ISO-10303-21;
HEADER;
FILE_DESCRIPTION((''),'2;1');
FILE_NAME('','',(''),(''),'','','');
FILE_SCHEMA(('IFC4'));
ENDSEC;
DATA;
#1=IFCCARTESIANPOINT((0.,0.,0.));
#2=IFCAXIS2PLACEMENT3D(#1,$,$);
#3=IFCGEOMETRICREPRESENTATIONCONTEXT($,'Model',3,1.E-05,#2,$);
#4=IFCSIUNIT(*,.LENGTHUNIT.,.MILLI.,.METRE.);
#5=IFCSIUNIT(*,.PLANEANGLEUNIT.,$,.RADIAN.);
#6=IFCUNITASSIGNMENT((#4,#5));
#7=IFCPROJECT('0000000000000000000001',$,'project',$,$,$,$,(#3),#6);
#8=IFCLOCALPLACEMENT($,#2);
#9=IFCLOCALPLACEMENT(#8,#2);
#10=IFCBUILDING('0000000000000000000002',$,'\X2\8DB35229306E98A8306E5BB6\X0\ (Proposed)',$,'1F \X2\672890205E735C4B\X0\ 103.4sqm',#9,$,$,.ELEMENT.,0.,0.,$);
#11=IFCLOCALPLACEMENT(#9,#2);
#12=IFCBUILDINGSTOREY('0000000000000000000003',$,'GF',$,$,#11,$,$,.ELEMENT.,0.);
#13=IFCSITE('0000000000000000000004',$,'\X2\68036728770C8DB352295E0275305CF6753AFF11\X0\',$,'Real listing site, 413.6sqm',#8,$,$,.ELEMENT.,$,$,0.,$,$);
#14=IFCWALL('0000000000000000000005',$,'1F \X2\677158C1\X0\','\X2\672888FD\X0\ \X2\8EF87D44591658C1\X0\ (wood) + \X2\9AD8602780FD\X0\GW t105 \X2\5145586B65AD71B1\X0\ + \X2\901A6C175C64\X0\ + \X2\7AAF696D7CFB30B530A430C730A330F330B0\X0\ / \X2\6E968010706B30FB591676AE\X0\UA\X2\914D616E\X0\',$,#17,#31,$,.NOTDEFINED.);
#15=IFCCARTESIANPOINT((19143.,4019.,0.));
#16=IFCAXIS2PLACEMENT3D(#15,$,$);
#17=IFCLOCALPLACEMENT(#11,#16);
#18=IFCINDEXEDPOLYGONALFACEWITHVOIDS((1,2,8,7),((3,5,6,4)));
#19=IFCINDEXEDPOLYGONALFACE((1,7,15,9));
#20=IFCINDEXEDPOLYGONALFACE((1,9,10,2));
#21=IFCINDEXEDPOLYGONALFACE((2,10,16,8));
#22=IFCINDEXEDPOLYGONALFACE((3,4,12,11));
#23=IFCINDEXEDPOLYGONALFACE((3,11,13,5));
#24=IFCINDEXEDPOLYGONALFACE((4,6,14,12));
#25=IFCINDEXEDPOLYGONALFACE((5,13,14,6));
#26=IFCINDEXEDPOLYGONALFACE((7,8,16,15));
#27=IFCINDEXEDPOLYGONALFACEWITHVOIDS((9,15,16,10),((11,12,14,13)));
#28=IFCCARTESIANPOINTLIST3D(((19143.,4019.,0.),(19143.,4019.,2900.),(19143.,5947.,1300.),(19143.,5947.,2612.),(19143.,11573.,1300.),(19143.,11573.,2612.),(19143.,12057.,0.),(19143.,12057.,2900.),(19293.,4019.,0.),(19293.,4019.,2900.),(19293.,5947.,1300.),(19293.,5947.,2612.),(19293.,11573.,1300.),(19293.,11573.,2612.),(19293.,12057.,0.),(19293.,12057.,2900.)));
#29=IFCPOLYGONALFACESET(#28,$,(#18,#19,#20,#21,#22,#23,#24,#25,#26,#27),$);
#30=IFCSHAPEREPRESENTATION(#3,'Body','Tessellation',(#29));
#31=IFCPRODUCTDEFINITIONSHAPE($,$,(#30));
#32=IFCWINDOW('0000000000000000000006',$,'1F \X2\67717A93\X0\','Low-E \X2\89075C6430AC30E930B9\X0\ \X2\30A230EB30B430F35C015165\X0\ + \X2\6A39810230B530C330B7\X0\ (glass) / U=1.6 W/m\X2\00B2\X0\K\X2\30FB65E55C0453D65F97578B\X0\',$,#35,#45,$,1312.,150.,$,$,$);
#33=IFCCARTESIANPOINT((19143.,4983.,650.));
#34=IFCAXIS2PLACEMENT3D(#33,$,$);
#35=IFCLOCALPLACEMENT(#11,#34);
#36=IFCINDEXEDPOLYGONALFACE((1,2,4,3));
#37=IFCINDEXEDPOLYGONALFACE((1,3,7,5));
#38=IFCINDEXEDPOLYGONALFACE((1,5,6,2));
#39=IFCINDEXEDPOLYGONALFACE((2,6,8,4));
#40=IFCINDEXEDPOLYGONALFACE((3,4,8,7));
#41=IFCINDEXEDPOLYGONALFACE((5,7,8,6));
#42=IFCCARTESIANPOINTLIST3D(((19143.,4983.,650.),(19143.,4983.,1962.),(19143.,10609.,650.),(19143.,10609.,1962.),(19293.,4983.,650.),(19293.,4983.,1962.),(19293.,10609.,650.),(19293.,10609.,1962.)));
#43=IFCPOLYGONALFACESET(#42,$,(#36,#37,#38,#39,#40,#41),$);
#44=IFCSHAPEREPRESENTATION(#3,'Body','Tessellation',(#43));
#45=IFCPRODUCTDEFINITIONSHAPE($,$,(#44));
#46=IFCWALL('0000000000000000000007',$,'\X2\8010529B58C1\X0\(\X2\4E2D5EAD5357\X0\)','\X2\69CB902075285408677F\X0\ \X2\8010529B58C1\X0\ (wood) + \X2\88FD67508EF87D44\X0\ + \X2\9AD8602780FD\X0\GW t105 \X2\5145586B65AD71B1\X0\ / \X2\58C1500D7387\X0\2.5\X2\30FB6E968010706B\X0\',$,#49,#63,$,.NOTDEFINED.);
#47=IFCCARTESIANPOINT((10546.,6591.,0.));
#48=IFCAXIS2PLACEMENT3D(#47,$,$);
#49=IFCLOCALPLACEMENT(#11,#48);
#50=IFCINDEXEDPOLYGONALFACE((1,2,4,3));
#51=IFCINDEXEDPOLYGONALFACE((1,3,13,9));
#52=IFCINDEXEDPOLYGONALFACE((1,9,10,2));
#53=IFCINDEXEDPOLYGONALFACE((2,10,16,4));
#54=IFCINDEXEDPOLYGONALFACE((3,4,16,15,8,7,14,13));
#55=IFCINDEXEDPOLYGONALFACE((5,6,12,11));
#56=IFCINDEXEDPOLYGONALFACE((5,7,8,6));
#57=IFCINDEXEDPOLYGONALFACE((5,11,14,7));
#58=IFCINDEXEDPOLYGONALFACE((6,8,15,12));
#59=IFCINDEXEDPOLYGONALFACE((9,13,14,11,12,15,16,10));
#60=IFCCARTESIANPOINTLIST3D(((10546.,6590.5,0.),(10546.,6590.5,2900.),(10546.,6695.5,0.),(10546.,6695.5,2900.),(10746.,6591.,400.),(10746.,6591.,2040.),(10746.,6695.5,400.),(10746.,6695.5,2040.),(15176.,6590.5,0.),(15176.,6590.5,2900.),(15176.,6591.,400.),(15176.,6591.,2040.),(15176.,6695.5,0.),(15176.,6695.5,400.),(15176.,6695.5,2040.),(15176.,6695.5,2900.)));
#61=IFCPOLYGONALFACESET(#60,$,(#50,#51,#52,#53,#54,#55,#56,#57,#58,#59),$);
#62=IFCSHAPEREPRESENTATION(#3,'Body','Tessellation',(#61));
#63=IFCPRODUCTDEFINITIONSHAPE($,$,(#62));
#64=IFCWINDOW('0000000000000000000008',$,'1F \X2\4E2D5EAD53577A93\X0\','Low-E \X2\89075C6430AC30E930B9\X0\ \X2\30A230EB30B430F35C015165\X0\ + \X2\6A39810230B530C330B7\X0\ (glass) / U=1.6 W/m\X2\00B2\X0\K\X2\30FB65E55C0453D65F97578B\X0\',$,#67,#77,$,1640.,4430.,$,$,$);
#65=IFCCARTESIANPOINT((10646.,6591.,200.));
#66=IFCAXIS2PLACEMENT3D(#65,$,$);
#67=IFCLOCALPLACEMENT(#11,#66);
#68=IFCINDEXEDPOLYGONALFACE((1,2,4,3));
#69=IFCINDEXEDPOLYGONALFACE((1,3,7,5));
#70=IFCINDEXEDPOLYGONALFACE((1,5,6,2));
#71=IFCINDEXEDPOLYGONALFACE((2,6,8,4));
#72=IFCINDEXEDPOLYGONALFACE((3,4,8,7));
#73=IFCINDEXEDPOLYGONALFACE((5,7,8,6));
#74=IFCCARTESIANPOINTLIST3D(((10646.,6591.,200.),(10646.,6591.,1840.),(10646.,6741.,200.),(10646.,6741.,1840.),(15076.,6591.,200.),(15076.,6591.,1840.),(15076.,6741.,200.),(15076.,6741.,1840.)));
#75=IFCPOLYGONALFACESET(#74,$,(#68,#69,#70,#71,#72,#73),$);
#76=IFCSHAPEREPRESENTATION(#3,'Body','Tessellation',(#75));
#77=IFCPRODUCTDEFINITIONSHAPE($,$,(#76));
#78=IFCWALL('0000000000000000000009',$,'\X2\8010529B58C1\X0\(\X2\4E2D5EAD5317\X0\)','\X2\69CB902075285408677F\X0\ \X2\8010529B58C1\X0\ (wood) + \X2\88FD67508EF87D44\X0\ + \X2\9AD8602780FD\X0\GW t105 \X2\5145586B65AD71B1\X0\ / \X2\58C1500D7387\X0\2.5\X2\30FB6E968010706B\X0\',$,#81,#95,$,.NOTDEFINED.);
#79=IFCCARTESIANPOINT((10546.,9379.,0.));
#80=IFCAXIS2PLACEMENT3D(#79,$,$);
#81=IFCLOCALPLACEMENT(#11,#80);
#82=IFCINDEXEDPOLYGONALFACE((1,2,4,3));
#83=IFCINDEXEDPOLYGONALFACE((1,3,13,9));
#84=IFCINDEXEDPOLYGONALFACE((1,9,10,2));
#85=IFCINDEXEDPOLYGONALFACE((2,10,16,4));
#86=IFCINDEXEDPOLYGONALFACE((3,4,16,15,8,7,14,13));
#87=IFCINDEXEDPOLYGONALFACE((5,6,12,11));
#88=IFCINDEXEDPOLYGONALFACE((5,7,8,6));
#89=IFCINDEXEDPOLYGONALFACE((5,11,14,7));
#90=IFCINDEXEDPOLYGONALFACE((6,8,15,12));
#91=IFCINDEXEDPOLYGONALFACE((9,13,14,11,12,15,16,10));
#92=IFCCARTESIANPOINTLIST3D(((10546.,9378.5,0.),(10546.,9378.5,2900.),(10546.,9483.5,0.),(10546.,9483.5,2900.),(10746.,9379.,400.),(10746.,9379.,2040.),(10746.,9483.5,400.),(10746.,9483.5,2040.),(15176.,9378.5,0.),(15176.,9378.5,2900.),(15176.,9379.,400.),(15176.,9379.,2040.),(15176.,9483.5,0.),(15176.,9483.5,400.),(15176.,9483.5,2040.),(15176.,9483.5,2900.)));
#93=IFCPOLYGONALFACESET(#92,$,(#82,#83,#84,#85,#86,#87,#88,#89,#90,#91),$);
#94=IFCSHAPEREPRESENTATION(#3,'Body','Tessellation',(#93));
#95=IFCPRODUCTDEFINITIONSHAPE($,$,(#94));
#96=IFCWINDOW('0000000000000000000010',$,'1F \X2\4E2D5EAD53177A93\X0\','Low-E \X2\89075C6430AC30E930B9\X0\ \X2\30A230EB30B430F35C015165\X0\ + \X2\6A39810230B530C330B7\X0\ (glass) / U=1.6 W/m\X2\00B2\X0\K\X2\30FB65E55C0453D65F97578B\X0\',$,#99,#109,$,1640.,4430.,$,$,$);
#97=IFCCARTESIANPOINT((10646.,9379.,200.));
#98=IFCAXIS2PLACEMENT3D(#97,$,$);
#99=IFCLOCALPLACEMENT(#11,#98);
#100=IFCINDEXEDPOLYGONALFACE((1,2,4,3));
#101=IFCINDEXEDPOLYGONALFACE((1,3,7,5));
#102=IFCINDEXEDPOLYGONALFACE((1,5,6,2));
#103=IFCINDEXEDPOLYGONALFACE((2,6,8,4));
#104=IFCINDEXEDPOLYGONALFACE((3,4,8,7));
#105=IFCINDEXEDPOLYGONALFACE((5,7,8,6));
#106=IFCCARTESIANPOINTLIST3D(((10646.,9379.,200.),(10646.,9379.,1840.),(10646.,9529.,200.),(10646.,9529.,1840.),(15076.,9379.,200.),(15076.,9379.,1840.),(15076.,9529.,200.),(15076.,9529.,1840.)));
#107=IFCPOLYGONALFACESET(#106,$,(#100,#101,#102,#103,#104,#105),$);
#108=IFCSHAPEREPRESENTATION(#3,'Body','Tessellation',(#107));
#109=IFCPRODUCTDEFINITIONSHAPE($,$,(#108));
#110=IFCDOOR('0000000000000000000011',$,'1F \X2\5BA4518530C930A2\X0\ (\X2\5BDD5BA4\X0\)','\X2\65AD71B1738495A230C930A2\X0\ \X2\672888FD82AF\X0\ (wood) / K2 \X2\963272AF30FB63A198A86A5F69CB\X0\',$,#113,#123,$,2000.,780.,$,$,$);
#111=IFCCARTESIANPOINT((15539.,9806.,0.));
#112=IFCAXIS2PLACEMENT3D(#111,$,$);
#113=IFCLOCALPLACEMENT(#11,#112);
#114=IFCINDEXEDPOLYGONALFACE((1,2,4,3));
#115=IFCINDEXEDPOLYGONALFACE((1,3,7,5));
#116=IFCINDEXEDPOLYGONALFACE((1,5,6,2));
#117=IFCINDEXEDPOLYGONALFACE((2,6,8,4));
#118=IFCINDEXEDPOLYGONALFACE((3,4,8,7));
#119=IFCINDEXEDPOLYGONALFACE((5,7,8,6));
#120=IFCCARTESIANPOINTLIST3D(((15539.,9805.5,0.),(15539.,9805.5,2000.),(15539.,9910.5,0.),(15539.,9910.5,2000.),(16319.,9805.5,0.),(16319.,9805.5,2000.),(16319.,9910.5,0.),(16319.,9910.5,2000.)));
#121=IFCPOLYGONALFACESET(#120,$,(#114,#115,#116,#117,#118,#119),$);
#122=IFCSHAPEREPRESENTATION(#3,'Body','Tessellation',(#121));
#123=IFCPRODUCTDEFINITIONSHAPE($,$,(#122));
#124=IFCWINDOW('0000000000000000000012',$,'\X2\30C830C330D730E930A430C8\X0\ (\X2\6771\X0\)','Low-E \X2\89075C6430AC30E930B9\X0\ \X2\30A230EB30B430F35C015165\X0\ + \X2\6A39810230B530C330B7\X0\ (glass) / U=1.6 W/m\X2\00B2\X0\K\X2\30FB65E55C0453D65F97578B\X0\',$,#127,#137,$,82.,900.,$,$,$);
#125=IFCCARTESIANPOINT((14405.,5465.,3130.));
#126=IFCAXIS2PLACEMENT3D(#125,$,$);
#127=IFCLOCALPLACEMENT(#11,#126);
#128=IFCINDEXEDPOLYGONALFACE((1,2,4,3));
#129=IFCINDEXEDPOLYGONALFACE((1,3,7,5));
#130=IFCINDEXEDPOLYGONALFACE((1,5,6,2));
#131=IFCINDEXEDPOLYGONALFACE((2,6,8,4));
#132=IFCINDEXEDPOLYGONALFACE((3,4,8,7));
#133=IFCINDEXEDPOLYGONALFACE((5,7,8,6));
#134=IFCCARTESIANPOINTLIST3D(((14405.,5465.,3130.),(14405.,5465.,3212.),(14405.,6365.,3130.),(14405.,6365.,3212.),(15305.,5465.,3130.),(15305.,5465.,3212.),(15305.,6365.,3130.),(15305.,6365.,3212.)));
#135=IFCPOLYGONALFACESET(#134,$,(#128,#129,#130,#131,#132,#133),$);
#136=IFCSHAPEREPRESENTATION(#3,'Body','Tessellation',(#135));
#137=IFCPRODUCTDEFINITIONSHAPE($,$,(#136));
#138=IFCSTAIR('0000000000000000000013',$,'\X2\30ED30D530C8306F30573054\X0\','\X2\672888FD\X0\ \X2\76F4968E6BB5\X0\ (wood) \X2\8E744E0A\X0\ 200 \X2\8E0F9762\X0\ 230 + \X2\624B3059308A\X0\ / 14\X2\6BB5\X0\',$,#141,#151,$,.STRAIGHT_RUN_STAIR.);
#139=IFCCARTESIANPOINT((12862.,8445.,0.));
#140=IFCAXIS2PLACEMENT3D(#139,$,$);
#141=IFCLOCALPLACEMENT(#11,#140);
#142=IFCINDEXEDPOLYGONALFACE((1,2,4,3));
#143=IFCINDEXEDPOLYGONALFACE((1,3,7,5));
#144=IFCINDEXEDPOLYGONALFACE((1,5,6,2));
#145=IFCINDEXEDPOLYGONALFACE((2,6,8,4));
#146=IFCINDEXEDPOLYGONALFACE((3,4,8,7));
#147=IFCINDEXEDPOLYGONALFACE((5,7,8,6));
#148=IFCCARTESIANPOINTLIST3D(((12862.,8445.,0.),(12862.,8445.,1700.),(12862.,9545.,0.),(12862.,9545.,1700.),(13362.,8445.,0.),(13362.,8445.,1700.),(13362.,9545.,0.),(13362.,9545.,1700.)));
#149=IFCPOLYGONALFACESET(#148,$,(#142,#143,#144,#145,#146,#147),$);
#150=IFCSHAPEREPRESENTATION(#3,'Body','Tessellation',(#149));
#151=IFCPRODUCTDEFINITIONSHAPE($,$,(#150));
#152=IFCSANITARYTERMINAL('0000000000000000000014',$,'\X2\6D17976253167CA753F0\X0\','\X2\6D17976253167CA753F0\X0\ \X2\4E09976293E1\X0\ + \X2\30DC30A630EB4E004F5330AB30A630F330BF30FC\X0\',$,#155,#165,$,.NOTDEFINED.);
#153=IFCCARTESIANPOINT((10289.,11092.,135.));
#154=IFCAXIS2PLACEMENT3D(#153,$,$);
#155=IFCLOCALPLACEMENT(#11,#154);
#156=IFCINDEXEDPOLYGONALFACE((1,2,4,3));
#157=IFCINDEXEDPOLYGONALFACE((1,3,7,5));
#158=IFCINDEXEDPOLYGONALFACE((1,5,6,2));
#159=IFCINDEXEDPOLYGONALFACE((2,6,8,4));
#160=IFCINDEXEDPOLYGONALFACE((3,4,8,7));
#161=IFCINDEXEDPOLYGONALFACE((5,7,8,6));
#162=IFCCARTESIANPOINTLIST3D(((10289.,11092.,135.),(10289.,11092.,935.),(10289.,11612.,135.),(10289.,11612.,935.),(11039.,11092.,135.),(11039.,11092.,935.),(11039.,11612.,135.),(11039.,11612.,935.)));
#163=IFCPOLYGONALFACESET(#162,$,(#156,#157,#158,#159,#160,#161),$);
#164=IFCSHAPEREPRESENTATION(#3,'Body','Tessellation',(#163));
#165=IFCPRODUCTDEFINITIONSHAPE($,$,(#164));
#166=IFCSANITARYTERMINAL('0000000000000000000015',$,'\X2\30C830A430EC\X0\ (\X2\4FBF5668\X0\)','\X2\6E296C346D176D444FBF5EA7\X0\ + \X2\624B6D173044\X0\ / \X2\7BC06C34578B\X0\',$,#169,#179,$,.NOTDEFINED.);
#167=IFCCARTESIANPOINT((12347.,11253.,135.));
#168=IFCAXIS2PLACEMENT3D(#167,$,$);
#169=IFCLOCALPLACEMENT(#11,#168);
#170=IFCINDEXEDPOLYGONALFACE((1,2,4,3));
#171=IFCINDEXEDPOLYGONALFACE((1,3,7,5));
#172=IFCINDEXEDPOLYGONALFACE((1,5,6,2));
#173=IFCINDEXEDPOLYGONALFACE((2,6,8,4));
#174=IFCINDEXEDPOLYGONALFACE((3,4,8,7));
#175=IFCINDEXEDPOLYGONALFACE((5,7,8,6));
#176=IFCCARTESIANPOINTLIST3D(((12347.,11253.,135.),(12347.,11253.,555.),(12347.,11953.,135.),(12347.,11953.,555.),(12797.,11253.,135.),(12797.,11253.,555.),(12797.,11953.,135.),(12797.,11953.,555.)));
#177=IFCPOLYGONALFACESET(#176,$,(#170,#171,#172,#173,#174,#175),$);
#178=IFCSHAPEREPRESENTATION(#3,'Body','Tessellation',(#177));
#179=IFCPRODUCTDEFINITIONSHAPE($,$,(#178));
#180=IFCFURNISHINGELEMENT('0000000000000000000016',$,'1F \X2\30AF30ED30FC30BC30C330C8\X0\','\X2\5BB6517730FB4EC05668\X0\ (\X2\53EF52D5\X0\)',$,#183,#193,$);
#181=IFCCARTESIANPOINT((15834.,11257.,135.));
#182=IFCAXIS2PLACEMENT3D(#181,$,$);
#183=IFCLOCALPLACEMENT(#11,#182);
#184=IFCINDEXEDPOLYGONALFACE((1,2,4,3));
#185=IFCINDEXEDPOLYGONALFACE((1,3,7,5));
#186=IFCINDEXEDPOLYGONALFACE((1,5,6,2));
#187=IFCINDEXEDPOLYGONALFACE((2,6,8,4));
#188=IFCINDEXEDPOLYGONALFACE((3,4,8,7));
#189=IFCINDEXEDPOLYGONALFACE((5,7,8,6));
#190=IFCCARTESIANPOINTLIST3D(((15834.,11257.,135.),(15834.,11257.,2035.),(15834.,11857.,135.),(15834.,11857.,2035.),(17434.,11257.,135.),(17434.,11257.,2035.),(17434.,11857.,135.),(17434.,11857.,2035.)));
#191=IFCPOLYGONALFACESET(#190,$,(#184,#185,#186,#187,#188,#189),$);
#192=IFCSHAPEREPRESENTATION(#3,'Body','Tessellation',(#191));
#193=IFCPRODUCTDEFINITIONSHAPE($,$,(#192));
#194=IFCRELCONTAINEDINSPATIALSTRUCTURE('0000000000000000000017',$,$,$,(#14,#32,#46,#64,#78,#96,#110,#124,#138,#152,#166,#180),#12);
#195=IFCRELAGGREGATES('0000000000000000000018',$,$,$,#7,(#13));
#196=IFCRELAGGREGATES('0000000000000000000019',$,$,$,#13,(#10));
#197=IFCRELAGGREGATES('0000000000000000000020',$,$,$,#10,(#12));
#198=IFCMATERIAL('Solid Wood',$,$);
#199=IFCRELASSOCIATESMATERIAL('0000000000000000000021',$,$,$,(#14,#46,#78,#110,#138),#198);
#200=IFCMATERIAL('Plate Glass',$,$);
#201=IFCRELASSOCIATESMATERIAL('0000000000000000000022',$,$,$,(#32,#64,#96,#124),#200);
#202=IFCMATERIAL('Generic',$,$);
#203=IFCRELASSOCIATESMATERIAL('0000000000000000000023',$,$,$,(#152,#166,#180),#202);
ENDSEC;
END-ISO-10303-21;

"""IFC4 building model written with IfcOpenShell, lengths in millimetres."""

from ifc_helpers import new_model, si_unit, frame, frame_2d, origin, place, context, project, spatial, rectangle, extrude, material, element, fill, save


model = new_model("IFC4")

# Units and contexts
model_context = context("Model", 3, precision=1e-05, world=origin())
ifc_project = project(units=[si_unit("LENGTHUNIT", "METRE", prefix="MILLI"), si_unit("PLANEANGLEUNIT", "RADIAN")], contexts=[model_context])

# Site, building, storey
site_placement = place(None, origin())
site = spatial("IfcSite", under=ifc_project, at=site_placement, Name="栃木県足利市田島町１", ObjectType="Real listing site, 413.6sqm", CompositionType="ELEMENT", RefElevation=0.0)
building_placement = place(site_placement, origin())
building = spatial("IfcBuilding", under=site, at=building_placement, Name="足利の風の家 (Proposed)", ObjectType="1F 木造平屋 103.4sqm", CompositionType="ELEMENT", ElevationOfRefHeight=0.0, ElevationOfTerrain=0.0)
storey_placement = place(building_placement, origin())
storey = spatial("IfcBuildingStorey", under=building, at=storey_placement, Name="GF", CompositionType="ELEMENT", Elevation=0.0)

# Shared definitions
ifc_material_1 = material(Name="Solid Wood")

# Walls, openings, windows
wall_1_placement = place(storey_placement, frame((19143.0, 4019.0, 0.0)))
wall_1 = element("IfcWall", 1, at=wall_1_placement, inside=storey, material=ifc_material_1, Name="1F 東壁", Description="木製 軸組外壁 (wood) + 高性能GW t105 充填断熱 + 通気層 + 窯業系サイディング / 準耐火・外皮UA配慮", PredefinedType="NOTDEFINED", context=model_context, shape_type="SweptSolid", body=[
    extrude(rectangle(XDim=150.0, YDim=8038.0, at=frame_2d((75.0, 4019.0))), frame((19143.0, 4019.0, 0.0)), (0.0, 0.0, 1.0), 2900.0),
])
opening_1_placement = place(storey_placement, frame((19143.0, 4983.0, 650.0)))
opening_1 = element("IfcOpeningElement", 2, at=opening_1_placement, cuts=wall_1, PredefinedType="NOTDEFINED", context=model_context, shape_type="SweptSolid", body=[
    extrude(rectangle(XDim=150.0, YDim=5626.0, at=frame_2d((75.0, 2813.0))), frame((19143.0, 4983.0, 650.0)), (0.0, 0.0, 1.0), 1312.0),
])
ifc_material_2 = material(Name="Plate Glass")
window_1_placement = place(storey_placement, frame((19143.0, 4983.0, 650.0)))
window_1 = element("IfcWindow", 3, at=window_1_placement, inside=storey, material=ifc_material_2, Name="1F 東窓", Description="Low-E 複層ガラス アルゴン封入 + 樹脂サッシ (glass) / U=1.6 W/m²K・日射取得型", OverallHeight=1312.0, OverallWidth=150.0, context=model_context, shape_type="SweptSolid", body=[
    extrude(rectangle(XDim=150.0, YDim=5626.0, at=frame_2d((75.0, 2813.0))), frame((19143.0, 4983.0, 650.0)), (0.0, 0.0, 1.0), 1312.0),
])
fill(opening_1, window_1)
wall_2_placement = place(storey_placement, frame((10546.0, 6591.0, 0.0)))
wall_2 = element("IfcWall", 4, at=wall_2_placement, inside=storey, material=ifc_material_1, Name="耐力壁(中庭南)", Description="構造用合板 耐力壁 (wood) + 製材軸組 + 高性能GW t105 充填断熱 / 壁倍率2.5・準耐火", PredefinedType="NOTDEFINED", context=model_context, shape_type="SweptSolid", body=[
    extrude(rectangle(XDim=4630.0, YDim=105.0, at=frame_2d((2315.0, 52.0))), frame((10546.0, 6591.0, 0.0)), (0.0, 0.0, 1.0), 2900.0),
])
opening_2_placement = place(storey_placement, frame((10646.0, 6591.0, 200.0)))
opening_2 = element("IfcOpeningElement", 5, at=opening_2_placement, cuts=wall_2, PredefinedType="NOTDEFINED", context=model_context, shape_type="SweptSolid", body=[
    extrude(rectangle(XDim=4430.0, YDim=150.0, at=frame_2d((2215.0, 75.0))), frame((10646.0, 6591.0, 200.0)), (0.0, 0.0, 1.0), 1640.0),
])
window_2_placement = place(storey_placement, frame((10646.0, 6591.0, 200.0)))
window_2 = element("IfcWindow", 6, at=window_2_placement, inside=storey, material=ifc_material_2, Name="1F 中庭南窓", Description="Low-E 複層ガラス アルゴン封入 + 樹脂サッシ (glass) / U=1.6 W/m²K・日射取得型", OverallHeight=1640.0, OverallWidth=4430.0, context=model_context, shape_type="SweptSolid", body=[
    extrude(rectangle(XDim=4430.0, YDim=150.0, at=frame_2d((2215.0, 75.0))), frame((10646.0, 6591.0, 200.0)), (0.0, 0.0, 1.0), 1640.0),
])
fill(opening_2, window_2)
wall_3_placement = place(storey_placement, frame((10546.0, 9379.0, 0.0)))
wall_3 = element("IfcWall", 7, at=wall_3_placement, inside=storey, material=ifc_material_1, Name="耐力壁(中庭北)", Description="構造用合板 耐力壁 (wood) + 製材軸組 + 高性能GW t105 充填断熱 / 壁倍率2.5・準耐火", PredefinedType="NOTDEFINED", context=model_context, shape_type="SweptSolid", body=[
    extrude(rectangle(XDim=4630.0, YDim=105.0, at=frame_2d((2315.0, 52.0))), frame((10546.0, 9379.0, 0.0)), (0.0, 0.0, 1.0), 2900.0),
])
opening_3_placement = place(storey_placement, frame((10646.0, 9379.0, 200.0)))
opening_3 = element("IfcOpeningElement", 8, at=opening_3_placement, cuts=wall_3, PredefinedType="NOTDEFINED", context=model_context, shape_type="SweptSolid", body=[
    extrude(rectangle(XDim=4430.0, YDim=150.0, at=frame_2d((2215.0, 75.0))), frame((10646.0, 9379.0, 200.0)), (0.0, 0.0, 1.0), 1640.0),
])
window_3_placement = place(storey_placement, frame((10646.0, 9379.0, 200.0)))
window_3 = element("IfcWindow", 9, at=window_3_placement, inside=storey, material=ifc_material_2, Name="1F 中庭北窓", Description="Low-E 複層ガラス アルゴン封入 + 樹脂サッシ (glass) / U=1.6 W/m²K・日射取得型", OverallHeight=1640.0, OverallWidth=4430.0, context=model_context, shape_type="SweptSolid", body=[
    extrude(rectangle(XDim=4430.0, YDim=150.0, at=frame_2d((2215.0, 75.0))), frame((10646.0, 9379.0, 200.0)), (0.0, 0.0, 1.0), 1640.0),
])
fill(opening_3, window_3)

# Door
door_placement = place(storey_placement, frame((15539.0, 9806.0, 0.0)))
element("IfcDoor", 10, at=door_placement, inside=storey, material=ifc_material_1, Name="1F 室内ドア (寝室)", Description="断熱玄関ドア 木製芯 (wood) / K2 防犯・採風機構", OverallHeight=2000.0, OverallWidth=780.0, context=model_context, shape_type="SweptSolid", body=[
    extrude(rectangle(XDim=780.0, YDim=105.0, at=frame_2d((390.0, 52.0))), frame((15539.0, 9806.0, 0.0)), (0.0, 0.0, 1.0), 2000.0),
])

# Window
window_4_placement = place(storey_placement, frame((14405.0, 5465.0, 3130.0)))
element("IfcWindow", 11, at=window_4_placement, inside=storey, material=ifc_material_2, Name="トップライト (東)", Description="Low-E 複層ガラス アルゴン封入 + 樹脂サッシ (glass) / U=1.6 W/m²K・日射取得型", OverallHeight=82.0, OverallWidth=900.0, context=model_context, shape_type="SweptSolid", body=[
    extrude(rectangle(XDim=900.0, YDim=900.0, at=frame_2d((450.0, 450.0))), frame((14405.0, 5465.0, 3130.0)), (0.0, 0.0, 1.0), 82.0),
])

# Stair
stair_placement = place(storey_placement, frame((12862.0, 8445.0, 0.0)))
element("IfcStair", 12, at=stair_placement, inside=storey, material=ifc_material_1, Name="ロフトはしご", Description="木製 直階段 (wood) 蹴上 200 踏面 230 + 手すり / 14段", PredefinedType="STRAIGHT_RUN_STAIR", context=model_context, shape_type="SweptSolid", body=[
    extrude(rectangle(XDim=500.0, YDim=1100.0, at=frame_2d((250.0, 550.0))), frame((12862.0, 8445.0, 0.0)), (0.0, 0.0, 1.0), 1700.0),
])

# Shared definitions
ifc_material_3 = material(Name="Generic")

# Sanitary terminals
sanitary_terminal_1_placement = place(storey_placement, frame((10289.0, 11092.0, 135.0)))
element("IfcSanitaryTerminal", 13, at=sanitary_terminal_1_placement, inside=storey, material=ifc_material_3, Name="洗面化粧台", Description="洗面化粧台 三面鏡 + ボウル一体カウンター", PredefinedType="NOTDEFINED", context=model_context, shape_type="SweptSolid", body=[
    extrude(rectangle(XDim=750.0, YDim=520.0, at=frame_2d((375.0, 260.0))), frame((10289.0, 11092.0, 135.0)), (0.0, 0.0, 1.0), 800.0),
])
sanitary_terminal_2_placement = place(storey_placement, frame((12347.0, 11253.0, 135.0)))
element("IfcSanitaryTerminal", 14, at=sanitary_terminal_2_placement, inside=storey, material=ifc_material_3, Name="トイレ (便器)", Description="温水洗浄便座 + 手洗い / 節水型", PredefinedType="NOTDEFINED", context=model_context, shape_type="SweptSolid", body=[
    extrude(rectangle(XDim=450.0, YDim=700.0, at=frame_2d((225.0, 350.0))), frame((12347.0, 11253.0, 135.0)), (0.0, 0.0, 1.0), 420.0),
])

# Furnishing element
furnishing_1_placement = place(storey_placement, frame((15834.0, 11257.0, 135.0)))
element("IfcFurnishingElement", 15, at=furnishing_1_placement, inside=storey, material=ifc_material_3, Name="1F クローゼット", Description="家具・什器 (可動)", context=model_context, shape_type="SweptSolid", body=[
    extrude(rectangle(XDim=1600.0, YDim=600.0, at=frame_2d((800.0, 300.0))), frame((15834.0, 11257.0, 135.0)), (0.0, 0.0, 1.0), 1900.0),
])

save(model, "model.ifc")
